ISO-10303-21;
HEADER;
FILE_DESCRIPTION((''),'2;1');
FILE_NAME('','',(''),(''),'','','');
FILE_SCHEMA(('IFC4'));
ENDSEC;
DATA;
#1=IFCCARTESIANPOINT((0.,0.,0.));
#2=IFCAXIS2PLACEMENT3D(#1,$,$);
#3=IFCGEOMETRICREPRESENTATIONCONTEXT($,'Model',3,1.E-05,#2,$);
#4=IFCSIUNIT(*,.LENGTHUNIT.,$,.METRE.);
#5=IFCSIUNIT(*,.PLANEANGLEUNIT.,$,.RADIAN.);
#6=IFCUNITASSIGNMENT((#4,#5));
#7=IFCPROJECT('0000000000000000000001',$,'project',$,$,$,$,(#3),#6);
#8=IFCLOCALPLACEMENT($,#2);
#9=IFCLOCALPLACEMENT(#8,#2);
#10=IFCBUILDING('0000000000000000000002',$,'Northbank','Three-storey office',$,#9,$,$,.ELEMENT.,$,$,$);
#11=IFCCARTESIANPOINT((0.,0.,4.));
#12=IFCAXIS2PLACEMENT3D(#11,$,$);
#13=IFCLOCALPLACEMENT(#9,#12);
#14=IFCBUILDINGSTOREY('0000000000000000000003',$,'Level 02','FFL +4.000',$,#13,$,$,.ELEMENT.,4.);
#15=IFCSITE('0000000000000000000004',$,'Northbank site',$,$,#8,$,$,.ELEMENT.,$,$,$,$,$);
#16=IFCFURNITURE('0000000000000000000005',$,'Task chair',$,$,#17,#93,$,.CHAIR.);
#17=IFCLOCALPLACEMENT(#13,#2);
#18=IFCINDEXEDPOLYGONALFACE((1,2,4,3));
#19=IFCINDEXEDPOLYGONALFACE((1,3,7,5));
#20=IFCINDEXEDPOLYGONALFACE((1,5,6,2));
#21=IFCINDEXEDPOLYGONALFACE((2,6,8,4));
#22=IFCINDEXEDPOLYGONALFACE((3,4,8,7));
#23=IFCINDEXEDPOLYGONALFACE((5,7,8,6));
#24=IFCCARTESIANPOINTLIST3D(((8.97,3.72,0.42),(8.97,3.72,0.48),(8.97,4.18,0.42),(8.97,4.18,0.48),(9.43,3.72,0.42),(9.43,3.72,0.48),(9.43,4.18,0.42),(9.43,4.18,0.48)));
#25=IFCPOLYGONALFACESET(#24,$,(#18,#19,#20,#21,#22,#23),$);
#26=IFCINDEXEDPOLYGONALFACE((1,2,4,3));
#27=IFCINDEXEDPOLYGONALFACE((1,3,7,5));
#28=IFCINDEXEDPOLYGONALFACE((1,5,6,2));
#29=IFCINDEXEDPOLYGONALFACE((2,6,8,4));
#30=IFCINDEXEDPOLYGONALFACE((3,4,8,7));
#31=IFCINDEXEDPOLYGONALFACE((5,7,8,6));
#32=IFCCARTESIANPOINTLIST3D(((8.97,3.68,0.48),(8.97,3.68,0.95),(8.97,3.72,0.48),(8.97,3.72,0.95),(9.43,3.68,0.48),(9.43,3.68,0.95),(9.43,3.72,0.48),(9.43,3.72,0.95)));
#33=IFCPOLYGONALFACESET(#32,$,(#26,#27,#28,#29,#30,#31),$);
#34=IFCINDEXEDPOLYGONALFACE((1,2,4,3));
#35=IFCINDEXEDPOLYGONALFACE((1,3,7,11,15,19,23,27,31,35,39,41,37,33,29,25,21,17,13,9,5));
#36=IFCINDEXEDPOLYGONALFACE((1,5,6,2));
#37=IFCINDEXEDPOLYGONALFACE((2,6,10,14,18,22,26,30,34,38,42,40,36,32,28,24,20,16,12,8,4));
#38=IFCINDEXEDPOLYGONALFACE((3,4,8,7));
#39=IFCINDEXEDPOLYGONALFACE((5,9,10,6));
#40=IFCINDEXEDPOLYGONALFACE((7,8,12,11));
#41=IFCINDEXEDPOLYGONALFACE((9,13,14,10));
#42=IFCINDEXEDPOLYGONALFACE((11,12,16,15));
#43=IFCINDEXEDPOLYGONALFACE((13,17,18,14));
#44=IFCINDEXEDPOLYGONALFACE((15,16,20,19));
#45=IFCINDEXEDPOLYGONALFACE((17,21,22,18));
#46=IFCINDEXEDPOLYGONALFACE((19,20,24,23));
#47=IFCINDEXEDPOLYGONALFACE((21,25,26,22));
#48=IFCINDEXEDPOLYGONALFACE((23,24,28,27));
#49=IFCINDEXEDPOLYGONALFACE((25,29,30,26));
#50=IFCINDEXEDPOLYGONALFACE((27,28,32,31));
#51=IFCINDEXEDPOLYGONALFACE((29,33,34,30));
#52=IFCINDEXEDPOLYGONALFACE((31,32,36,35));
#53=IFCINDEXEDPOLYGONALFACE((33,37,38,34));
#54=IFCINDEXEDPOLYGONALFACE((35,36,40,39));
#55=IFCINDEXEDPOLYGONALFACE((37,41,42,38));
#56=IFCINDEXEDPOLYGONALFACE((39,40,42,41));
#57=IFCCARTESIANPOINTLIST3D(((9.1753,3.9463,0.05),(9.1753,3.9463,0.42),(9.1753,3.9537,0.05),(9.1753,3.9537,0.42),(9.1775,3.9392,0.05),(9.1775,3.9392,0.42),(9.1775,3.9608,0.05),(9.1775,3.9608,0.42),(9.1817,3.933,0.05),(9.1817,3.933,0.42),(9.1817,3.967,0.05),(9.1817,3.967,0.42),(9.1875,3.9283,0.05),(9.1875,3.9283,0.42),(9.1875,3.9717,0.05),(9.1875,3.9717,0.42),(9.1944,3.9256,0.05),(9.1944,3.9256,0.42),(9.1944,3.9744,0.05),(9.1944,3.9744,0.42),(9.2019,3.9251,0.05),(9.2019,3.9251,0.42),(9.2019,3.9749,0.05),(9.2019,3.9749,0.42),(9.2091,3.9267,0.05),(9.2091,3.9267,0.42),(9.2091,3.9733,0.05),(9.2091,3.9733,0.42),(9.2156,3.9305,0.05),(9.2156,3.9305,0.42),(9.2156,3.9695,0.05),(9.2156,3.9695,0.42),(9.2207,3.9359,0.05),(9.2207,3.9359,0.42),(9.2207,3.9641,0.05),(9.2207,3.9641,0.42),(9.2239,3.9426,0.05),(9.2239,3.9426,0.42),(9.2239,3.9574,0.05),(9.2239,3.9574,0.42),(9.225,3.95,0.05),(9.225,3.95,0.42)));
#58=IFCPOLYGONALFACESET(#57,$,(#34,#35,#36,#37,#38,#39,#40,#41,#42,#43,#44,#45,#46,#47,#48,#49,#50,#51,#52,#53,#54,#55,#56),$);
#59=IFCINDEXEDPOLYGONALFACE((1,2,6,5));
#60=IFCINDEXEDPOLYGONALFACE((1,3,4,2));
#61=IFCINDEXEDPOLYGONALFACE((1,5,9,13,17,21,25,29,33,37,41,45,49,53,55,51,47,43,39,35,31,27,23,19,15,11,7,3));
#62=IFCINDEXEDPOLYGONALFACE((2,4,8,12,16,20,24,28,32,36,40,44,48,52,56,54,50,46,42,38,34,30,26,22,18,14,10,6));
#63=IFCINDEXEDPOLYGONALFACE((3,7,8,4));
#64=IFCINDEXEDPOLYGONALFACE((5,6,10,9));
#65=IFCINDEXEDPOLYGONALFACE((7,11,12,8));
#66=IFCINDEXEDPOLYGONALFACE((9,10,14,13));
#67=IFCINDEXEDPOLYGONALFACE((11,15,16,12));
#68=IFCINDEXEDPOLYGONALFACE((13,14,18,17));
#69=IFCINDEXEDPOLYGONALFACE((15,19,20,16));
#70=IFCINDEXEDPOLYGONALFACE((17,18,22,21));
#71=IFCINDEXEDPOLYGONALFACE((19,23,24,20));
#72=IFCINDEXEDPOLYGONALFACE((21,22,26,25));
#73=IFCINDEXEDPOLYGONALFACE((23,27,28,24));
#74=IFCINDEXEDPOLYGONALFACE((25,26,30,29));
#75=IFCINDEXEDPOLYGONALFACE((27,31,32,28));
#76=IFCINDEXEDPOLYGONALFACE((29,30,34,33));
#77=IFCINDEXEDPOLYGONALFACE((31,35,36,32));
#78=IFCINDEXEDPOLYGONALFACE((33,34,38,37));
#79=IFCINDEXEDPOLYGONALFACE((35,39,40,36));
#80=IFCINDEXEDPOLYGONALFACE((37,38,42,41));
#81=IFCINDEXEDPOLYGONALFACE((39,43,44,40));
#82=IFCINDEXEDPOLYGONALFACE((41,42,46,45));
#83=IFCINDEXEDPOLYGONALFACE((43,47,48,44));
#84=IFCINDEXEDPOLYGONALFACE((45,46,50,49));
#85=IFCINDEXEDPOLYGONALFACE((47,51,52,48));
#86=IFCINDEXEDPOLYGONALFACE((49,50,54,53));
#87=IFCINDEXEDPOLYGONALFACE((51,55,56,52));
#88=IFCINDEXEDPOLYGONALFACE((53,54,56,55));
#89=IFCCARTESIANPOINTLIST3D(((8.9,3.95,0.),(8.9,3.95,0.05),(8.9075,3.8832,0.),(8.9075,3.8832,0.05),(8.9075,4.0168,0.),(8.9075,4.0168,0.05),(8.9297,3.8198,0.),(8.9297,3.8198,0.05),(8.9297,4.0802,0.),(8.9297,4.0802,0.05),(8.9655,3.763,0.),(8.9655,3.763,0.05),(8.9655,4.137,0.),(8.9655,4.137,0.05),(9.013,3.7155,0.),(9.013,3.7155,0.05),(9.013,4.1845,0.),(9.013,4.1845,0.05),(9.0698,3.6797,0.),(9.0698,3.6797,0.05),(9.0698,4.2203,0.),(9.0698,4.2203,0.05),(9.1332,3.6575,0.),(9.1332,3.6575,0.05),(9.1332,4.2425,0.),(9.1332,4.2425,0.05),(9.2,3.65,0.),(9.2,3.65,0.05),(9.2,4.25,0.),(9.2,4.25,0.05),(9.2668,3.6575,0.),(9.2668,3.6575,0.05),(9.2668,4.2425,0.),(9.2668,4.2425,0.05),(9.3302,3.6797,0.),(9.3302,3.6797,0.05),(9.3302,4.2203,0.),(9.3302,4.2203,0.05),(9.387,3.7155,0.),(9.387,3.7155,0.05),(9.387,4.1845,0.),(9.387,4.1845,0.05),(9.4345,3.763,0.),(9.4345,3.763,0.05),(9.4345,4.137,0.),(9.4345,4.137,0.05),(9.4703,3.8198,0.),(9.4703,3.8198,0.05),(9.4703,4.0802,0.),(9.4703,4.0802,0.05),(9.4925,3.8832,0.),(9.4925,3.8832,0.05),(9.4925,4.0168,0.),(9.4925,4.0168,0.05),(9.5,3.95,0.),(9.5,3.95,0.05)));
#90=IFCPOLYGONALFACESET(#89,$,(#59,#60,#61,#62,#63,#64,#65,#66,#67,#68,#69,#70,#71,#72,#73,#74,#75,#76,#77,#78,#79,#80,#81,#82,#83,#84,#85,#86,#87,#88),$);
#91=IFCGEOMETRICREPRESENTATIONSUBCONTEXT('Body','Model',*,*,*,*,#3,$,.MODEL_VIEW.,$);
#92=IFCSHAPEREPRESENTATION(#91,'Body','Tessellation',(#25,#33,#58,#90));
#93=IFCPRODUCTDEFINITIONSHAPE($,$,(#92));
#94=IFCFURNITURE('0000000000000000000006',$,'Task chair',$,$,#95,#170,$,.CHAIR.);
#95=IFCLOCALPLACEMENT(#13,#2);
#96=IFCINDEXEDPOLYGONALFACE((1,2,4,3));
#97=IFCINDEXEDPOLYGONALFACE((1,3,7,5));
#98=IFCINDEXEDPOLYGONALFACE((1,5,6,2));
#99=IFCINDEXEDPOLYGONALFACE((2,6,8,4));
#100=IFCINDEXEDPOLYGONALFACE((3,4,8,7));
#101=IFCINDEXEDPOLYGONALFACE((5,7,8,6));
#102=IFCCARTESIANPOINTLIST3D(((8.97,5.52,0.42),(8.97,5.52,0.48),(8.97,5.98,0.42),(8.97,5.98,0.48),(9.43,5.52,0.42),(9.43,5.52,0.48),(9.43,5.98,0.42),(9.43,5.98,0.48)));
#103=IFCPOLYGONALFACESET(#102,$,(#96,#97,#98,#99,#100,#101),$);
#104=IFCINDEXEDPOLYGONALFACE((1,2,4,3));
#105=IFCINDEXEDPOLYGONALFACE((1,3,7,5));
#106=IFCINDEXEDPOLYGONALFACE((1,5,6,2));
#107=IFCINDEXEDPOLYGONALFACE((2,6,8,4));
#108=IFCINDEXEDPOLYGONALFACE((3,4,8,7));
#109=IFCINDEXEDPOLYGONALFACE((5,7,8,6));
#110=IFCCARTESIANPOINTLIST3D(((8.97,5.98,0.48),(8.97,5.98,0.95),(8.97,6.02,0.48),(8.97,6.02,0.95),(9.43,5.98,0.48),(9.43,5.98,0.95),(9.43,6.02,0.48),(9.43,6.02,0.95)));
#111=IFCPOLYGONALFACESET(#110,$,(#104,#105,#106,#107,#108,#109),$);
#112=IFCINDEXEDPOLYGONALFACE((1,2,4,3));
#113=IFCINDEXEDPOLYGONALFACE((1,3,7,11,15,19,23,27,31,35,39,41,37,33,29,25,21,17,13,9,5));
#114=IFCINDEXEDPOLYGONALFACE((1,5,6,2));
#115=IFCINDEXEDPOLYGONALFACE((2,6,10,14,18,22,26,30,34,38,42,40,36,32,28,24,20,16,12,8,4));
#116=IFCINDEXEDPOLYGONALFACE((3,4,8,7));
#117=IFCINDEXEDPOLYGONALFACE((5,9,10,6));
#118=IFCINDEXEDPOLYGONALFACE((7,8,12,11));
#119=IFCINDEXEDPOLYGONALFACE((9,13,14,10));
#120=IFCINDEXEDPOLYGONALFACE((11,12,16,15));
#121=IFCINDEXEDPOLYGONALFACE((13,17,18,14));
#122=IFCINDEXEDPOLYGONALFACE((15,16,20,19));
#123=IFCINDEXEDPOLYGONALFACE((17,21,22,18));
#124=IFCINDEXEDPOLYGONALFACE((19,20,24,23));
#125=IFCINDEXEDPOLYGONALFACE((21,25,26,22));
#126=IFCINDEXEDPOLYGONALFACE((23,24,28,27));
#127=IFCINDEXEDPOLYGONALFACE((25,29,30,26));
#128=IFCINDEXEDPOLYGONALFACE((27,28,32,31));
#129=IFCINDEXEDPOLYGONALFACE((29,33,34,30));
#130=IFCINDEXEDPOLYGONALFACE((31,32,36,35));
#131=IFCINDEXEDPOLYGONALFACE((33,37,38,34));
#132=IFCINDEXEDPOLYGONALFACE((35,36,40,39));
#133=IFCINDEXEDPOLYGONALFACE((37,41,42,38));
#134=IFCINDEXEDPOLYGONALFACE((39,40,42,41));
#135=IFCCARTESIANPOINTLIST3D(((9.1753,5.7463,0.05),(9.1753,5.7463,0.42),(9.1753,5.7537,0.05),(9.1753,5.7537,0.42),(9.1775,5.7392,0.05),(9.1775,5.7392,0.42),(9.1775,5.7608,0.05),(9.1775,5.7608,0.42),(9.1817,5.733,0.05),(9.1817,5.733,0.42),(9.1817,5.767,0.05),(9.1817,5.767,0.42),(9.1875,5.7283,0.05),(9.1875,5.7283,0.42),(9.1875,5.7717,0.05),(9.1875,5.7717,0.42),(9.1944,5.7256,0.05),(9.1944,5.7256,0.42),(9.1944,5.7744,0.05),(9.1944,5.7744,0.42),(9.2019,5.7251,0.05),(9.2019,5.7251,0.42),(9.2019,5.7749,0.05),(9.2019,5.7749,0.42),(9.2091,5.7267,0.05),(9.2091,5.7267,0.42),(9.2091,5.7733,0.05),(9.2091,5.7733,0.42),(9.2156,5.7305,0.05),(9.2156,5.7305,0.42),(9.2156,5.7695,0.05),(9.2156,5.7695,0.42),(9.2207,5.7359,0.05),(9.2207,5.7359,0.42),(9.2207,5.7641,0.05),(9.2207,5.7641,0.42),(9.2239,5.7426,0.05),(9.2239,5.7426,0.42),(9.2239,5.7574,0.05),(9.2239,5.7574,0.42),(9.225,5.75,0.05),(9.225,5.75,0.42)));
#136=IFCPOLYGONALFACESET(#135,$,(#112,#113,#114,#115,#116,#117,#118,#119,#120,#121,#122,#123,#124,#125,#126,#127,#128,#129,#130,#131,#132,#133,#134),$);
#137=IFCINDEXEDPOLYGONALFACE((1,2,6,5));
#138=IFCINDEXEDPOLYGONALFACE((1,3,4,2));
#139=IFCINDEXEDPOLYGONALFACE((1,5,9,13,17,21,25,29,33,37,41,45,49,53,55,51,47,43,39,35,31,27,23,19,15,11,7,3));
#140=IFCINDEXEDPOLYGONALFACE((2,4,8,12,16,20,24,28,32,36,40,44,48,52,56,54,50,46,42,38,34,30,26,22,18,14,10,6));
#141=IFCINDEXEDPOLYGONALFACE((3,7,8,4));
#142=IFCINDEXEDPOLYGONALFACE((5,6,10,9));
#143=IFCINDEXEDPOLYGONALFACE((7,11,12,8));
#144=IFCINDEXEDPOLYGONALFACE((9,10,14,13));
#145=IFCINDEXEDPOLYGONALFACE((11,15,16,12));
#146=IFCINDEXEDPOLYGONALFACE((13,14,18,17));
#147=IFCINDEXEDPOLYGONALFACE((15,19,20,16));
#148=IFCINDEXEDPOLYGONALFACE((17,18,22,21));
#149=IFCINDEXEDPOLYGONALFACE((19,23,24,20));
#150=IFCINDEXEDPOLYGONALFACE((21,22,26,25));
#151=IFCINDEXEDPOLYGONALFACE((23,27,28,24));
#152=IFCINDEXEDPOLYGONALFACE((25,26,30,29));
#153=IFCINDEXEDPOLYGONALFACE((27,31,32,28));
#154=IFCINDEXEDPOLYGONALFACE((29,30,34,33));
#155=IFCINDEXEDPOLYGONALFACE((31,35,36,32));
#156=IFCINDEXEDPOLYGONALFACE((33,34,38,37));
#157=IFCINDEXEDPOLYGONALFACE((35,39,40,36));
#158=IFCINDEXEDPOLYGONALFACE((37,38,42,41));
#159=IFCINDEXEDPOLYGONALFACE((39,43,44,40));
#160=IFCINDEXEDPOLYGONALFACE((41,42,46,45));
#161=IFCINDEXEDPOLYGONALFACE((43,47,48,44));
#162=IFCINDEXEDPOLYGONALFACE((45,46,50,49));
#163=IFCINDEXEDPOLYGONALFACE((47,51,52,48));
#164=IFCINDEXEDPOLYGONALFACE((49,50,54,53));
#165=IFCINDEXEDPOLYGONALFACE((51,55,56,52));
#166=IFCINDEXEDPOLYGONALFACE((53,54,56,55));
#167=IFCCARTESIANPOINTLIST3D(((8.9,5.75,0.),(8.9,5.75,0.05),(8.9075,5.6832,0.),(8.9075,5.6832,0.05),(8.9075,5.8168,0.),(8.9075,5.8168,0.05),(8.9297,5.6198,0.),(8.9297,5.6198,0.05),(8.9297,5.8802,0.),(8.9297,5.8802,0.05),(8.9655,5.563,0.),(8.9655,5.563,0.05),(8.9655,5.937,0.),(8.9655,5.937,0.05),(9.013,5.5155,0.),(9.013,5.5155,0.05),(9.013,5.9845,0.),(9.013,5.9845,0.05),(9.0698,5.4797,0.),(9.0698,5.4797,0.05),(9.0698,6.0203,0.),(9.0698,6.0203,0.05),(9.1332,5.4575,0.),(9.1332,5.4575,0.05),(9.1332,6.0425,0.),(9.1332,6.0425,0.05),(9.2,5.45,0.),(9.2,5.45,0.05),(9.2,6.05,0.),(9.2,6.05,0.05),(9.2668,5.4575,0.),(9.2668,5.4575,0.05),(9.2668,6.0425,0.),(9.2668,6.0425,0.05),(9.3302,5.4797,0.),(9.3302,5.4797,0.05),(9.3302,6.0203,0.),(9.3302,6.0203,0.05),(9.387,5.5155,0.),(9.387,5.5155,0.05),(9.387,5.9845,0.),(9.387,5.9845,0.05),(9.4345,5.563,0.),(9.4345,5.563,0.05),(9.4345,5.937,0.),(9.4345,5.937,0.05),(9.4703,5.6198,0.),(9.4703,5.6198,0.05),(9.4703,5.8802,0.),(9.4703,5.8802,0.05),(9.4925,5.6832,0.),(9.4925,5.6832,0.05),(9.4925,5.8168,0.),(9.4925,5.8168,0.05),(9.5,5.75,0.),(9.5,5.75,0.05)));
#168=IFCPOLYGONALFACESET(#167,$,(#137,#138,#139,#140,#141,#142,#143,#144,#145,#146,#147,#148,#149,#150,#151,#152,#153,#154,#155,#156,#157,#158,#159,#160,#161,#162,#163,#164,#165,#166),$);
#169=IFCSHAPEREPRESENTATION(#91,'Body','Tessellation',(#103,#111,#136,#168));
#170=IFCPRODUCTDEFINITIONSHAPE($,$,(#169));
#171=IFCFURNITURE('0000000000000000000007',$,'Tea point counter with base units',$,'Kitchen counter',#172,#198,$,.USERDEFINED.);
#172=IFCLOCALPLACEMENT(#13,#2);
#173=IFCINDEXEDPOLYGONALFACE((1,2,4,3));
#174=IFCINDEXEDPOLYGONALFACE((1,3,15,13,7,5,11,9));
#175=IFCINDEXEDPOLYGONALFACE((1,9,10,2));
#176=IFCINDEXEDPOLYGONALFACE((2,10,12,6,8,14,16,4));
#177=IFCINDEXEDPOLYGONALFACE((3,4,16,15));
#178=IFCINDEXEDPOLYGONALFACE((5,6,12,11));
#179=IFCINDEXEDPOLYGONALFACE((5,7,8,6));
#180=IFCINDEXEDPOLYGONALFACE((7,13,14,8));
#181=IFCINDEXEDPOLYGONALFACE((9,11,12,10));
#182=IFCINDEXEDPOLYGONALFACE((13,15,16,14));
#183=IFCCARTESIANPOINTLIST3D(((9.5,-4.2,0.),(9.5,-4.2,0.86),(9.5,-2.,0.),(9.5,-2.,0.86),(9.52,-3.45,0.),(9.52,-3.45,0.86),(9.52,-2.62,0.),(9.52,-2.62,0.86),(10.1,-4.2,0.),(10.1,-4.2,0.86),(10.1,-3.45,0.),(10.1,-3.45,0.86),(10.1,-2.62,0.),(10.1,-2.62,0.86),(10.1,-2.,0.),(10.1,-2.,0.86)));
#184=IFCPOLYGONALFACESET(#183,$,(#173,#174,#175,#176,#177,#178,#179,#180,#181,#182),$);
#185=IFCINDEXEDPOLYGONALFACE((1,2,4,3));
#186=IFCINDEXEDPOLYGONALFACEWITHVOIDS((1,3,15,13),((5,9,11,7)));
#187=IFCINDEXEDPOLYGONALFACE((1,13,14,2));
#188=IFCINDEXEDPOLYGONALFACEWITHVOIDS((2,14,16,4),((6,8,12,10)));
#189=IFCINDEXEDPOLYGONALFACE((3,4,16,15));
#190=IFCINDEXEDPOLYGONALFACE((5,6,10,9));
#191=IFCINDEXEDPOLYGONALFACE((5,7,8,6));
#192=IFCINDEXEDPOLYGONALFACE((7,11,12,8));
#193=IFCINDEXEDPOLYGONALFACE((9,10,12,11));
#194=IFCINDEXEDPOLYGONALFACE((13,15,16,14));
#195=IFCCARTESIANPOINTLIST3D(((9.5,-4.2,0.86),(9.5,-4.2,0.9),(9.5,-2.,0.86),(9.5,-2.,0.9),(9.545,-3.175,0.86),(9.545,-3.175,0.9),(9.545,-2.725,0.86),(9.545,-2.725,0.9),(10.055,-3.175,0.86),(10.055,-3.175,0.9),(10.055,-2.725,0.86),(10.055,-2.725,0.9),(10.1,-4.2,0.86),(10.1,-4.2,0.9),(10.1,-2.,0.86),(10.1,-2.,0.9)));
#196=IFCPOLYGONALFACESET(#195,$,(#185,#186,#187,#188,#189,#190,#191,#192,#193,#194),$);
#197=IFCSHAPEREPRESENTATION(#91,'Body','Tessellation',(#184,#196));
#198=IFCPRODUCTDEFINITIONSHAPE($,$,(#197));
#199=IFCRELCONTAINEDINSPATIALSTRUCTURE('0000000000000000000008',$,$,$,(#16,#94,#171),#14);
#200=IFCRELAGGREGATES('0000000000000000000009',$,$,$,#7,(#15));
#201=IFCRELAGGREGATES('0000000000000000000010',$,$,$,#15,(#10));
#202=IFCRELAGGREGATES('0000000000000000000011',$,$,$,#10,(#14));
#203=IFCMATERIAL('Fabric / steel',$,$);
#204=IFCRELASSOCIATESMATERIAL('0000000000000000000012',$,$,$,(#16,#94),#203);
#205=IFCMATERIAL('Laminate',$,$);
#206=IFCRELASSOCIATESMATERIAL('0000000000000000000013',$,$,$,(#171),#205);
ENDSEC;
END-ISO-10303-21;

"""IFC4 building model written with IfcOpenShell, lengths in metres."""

from ifc_helpers import new_model, si_unit, frame, origin, place, context, subcontext, project, spatial, polyline, rectangle, circle, outline, extrude, material, element, save


model = new_model("IFC4")

# Units and contexts
model_context = context("Model", 3, precision=1e-05, world=origin())
body_context = subcontext(model_context, "Body", "Model", "MODEL_VIEW")
ifc_project = project(units=[si_unit("LENGTHUNIT", "METRE"), si_unit("PLANEANGLEUNIT", "RADIAN")], contexts=[model_context])

# Site, building, storey
site_placement = place(None, origin())
site = spatial("IfcSite", under=ifc_project, at=site_placement, Name="Northbank site", CompositionType="ELEMENT")
building_placement = place(site_placement, origin())
building = spatial("IfcBuilding", under=site, at=building_placement, Name="Northbank", Description="Three-storey office", CompositionType="ELEMENT")
storey_placement = place(building_placement, frame((0.0, 0.0, 4.0)))
storey = spatial("IfcBuildingStorey", under=building, at=storey_placement, Name="Level 02", Description="FFL +4.000", CompositionType="ELEMENT", Elevation=4.0)

# Furniture
ifc_material_1 = material(Name="Fabric / steel")
furniture_1_placement = place(storey_placement, frame((0.0, 0.0, -4.0)))
element("IfcFurniture", 1, at=furniture_1_placement, inside=storey, material=ifc_material_1, Name="Task chair", PredefinedType="CHAIR", context=body_context, shape_type="SweptSolid", body=[
    extrude(rectangle(XDim=0.46, YDim=0.46), frame((9.2, 3.95, 4.42)), (0.0, 0.0, 1.0), 0.06),
    extrude(rectangle(XDim=0.46, YDim=0.04), frame((9.2, 3.7, 4.48)), (0.0, 0.0, 1.0), 0.47),
    extrude(circle(Radius=0.025), frame((9.2, 3.95, 4.05), z_axis=(0.0, 0.0, 1.0), x_axis=(1.0, 0.0, 0.0)), (0.0, 0.0, 1.0), 0.37),
    extrude(circle(Radius=0.3), frame((9.2, 3.95, 4.0), z_axis=(0.0, 0.0, 1.0), x_axis=(1.0, 0.0, 0.0)), (0.0, 0.0, 1.0), 0.05),
])
furniture_2_placement = place(storey_placement, frame((0.0, 0.0, -4.0)))
element("IfcFurniture", 2, at=furniture_2_placement, inside=storey, material=ifc_material_1, Name="Task chair", PredefinedType="CHAIR", context=body_context, shape_type="SweptSolid", body=[
    extrude(rectangle(XDim=0.46, YDim=0.46), frame((9.2, 5.75, 4.42)), (0.0, 0.0, 1.0), 0.06),
    extrude(rectangle(XDim=0.46, YDim=0.04), frame((9.2, 6.0, 4.48)), (0.0, 0.0, 1.0), 0.47),
    extrude(circle(Radius=0.025), frame((9.2, 5.75, 4.05), z_axis=(0.0, 0.0, 1.0), x_axis=(1.0, 0.0, 0.0)), (0.0, 0.0, 1.0), 0.37),
    extrude(circle(Radius=0.3), frame((9.2, 5.75, 4.0), z_axis=(0.0, 0.0, 1.0), x_axis=(1.0, 0.0, 0.0)), (0.0, 0.0, 1.0), 0.05),
])
ifc_material_2 = material(Name="Laminate")
furniture_3_placement = place(storey_placement, frame((0.0, 0.0, -4.0)))
element("IfcFurniture", 3, at=furniture_3_placement, inside=storey, material=ifc_material_2, Name="Tea point counter with base units", ObjectType="Kitchen counter", PredefinedType="USERDEFINED", context=body_context, shape_type="SweptSolid", body=[
    extrude(outline(polyline([(9.5, -4.2), (10.1, -4.2), (10.1, -3.45), (9.52, -3.45), (9.52, -2.62), (10.1, -2.62), (10.1, -2.0), (9.5, -2.0), (9.5, -4.2)])), frame((0.0, 0.0, 4.0)), (0.0, 0.0, 1.0), 0.86),
    extrude(outline(polyline([(9.5, -4.2), (10.1, -4.2), (10.1, -2.0), (9.5, -2.0), (9.5, -4.2)]), holes=[polyline([(9.545, -3.175), (9.545, -2.725), (10.055, -2.725), (10.055, -3.175), (9.545, -3.175)])]), frame((0.0, 0.0, 4.86)), (0.0, 0.0, 1.0), 0.04),
])

save(model, "model.ifc")
